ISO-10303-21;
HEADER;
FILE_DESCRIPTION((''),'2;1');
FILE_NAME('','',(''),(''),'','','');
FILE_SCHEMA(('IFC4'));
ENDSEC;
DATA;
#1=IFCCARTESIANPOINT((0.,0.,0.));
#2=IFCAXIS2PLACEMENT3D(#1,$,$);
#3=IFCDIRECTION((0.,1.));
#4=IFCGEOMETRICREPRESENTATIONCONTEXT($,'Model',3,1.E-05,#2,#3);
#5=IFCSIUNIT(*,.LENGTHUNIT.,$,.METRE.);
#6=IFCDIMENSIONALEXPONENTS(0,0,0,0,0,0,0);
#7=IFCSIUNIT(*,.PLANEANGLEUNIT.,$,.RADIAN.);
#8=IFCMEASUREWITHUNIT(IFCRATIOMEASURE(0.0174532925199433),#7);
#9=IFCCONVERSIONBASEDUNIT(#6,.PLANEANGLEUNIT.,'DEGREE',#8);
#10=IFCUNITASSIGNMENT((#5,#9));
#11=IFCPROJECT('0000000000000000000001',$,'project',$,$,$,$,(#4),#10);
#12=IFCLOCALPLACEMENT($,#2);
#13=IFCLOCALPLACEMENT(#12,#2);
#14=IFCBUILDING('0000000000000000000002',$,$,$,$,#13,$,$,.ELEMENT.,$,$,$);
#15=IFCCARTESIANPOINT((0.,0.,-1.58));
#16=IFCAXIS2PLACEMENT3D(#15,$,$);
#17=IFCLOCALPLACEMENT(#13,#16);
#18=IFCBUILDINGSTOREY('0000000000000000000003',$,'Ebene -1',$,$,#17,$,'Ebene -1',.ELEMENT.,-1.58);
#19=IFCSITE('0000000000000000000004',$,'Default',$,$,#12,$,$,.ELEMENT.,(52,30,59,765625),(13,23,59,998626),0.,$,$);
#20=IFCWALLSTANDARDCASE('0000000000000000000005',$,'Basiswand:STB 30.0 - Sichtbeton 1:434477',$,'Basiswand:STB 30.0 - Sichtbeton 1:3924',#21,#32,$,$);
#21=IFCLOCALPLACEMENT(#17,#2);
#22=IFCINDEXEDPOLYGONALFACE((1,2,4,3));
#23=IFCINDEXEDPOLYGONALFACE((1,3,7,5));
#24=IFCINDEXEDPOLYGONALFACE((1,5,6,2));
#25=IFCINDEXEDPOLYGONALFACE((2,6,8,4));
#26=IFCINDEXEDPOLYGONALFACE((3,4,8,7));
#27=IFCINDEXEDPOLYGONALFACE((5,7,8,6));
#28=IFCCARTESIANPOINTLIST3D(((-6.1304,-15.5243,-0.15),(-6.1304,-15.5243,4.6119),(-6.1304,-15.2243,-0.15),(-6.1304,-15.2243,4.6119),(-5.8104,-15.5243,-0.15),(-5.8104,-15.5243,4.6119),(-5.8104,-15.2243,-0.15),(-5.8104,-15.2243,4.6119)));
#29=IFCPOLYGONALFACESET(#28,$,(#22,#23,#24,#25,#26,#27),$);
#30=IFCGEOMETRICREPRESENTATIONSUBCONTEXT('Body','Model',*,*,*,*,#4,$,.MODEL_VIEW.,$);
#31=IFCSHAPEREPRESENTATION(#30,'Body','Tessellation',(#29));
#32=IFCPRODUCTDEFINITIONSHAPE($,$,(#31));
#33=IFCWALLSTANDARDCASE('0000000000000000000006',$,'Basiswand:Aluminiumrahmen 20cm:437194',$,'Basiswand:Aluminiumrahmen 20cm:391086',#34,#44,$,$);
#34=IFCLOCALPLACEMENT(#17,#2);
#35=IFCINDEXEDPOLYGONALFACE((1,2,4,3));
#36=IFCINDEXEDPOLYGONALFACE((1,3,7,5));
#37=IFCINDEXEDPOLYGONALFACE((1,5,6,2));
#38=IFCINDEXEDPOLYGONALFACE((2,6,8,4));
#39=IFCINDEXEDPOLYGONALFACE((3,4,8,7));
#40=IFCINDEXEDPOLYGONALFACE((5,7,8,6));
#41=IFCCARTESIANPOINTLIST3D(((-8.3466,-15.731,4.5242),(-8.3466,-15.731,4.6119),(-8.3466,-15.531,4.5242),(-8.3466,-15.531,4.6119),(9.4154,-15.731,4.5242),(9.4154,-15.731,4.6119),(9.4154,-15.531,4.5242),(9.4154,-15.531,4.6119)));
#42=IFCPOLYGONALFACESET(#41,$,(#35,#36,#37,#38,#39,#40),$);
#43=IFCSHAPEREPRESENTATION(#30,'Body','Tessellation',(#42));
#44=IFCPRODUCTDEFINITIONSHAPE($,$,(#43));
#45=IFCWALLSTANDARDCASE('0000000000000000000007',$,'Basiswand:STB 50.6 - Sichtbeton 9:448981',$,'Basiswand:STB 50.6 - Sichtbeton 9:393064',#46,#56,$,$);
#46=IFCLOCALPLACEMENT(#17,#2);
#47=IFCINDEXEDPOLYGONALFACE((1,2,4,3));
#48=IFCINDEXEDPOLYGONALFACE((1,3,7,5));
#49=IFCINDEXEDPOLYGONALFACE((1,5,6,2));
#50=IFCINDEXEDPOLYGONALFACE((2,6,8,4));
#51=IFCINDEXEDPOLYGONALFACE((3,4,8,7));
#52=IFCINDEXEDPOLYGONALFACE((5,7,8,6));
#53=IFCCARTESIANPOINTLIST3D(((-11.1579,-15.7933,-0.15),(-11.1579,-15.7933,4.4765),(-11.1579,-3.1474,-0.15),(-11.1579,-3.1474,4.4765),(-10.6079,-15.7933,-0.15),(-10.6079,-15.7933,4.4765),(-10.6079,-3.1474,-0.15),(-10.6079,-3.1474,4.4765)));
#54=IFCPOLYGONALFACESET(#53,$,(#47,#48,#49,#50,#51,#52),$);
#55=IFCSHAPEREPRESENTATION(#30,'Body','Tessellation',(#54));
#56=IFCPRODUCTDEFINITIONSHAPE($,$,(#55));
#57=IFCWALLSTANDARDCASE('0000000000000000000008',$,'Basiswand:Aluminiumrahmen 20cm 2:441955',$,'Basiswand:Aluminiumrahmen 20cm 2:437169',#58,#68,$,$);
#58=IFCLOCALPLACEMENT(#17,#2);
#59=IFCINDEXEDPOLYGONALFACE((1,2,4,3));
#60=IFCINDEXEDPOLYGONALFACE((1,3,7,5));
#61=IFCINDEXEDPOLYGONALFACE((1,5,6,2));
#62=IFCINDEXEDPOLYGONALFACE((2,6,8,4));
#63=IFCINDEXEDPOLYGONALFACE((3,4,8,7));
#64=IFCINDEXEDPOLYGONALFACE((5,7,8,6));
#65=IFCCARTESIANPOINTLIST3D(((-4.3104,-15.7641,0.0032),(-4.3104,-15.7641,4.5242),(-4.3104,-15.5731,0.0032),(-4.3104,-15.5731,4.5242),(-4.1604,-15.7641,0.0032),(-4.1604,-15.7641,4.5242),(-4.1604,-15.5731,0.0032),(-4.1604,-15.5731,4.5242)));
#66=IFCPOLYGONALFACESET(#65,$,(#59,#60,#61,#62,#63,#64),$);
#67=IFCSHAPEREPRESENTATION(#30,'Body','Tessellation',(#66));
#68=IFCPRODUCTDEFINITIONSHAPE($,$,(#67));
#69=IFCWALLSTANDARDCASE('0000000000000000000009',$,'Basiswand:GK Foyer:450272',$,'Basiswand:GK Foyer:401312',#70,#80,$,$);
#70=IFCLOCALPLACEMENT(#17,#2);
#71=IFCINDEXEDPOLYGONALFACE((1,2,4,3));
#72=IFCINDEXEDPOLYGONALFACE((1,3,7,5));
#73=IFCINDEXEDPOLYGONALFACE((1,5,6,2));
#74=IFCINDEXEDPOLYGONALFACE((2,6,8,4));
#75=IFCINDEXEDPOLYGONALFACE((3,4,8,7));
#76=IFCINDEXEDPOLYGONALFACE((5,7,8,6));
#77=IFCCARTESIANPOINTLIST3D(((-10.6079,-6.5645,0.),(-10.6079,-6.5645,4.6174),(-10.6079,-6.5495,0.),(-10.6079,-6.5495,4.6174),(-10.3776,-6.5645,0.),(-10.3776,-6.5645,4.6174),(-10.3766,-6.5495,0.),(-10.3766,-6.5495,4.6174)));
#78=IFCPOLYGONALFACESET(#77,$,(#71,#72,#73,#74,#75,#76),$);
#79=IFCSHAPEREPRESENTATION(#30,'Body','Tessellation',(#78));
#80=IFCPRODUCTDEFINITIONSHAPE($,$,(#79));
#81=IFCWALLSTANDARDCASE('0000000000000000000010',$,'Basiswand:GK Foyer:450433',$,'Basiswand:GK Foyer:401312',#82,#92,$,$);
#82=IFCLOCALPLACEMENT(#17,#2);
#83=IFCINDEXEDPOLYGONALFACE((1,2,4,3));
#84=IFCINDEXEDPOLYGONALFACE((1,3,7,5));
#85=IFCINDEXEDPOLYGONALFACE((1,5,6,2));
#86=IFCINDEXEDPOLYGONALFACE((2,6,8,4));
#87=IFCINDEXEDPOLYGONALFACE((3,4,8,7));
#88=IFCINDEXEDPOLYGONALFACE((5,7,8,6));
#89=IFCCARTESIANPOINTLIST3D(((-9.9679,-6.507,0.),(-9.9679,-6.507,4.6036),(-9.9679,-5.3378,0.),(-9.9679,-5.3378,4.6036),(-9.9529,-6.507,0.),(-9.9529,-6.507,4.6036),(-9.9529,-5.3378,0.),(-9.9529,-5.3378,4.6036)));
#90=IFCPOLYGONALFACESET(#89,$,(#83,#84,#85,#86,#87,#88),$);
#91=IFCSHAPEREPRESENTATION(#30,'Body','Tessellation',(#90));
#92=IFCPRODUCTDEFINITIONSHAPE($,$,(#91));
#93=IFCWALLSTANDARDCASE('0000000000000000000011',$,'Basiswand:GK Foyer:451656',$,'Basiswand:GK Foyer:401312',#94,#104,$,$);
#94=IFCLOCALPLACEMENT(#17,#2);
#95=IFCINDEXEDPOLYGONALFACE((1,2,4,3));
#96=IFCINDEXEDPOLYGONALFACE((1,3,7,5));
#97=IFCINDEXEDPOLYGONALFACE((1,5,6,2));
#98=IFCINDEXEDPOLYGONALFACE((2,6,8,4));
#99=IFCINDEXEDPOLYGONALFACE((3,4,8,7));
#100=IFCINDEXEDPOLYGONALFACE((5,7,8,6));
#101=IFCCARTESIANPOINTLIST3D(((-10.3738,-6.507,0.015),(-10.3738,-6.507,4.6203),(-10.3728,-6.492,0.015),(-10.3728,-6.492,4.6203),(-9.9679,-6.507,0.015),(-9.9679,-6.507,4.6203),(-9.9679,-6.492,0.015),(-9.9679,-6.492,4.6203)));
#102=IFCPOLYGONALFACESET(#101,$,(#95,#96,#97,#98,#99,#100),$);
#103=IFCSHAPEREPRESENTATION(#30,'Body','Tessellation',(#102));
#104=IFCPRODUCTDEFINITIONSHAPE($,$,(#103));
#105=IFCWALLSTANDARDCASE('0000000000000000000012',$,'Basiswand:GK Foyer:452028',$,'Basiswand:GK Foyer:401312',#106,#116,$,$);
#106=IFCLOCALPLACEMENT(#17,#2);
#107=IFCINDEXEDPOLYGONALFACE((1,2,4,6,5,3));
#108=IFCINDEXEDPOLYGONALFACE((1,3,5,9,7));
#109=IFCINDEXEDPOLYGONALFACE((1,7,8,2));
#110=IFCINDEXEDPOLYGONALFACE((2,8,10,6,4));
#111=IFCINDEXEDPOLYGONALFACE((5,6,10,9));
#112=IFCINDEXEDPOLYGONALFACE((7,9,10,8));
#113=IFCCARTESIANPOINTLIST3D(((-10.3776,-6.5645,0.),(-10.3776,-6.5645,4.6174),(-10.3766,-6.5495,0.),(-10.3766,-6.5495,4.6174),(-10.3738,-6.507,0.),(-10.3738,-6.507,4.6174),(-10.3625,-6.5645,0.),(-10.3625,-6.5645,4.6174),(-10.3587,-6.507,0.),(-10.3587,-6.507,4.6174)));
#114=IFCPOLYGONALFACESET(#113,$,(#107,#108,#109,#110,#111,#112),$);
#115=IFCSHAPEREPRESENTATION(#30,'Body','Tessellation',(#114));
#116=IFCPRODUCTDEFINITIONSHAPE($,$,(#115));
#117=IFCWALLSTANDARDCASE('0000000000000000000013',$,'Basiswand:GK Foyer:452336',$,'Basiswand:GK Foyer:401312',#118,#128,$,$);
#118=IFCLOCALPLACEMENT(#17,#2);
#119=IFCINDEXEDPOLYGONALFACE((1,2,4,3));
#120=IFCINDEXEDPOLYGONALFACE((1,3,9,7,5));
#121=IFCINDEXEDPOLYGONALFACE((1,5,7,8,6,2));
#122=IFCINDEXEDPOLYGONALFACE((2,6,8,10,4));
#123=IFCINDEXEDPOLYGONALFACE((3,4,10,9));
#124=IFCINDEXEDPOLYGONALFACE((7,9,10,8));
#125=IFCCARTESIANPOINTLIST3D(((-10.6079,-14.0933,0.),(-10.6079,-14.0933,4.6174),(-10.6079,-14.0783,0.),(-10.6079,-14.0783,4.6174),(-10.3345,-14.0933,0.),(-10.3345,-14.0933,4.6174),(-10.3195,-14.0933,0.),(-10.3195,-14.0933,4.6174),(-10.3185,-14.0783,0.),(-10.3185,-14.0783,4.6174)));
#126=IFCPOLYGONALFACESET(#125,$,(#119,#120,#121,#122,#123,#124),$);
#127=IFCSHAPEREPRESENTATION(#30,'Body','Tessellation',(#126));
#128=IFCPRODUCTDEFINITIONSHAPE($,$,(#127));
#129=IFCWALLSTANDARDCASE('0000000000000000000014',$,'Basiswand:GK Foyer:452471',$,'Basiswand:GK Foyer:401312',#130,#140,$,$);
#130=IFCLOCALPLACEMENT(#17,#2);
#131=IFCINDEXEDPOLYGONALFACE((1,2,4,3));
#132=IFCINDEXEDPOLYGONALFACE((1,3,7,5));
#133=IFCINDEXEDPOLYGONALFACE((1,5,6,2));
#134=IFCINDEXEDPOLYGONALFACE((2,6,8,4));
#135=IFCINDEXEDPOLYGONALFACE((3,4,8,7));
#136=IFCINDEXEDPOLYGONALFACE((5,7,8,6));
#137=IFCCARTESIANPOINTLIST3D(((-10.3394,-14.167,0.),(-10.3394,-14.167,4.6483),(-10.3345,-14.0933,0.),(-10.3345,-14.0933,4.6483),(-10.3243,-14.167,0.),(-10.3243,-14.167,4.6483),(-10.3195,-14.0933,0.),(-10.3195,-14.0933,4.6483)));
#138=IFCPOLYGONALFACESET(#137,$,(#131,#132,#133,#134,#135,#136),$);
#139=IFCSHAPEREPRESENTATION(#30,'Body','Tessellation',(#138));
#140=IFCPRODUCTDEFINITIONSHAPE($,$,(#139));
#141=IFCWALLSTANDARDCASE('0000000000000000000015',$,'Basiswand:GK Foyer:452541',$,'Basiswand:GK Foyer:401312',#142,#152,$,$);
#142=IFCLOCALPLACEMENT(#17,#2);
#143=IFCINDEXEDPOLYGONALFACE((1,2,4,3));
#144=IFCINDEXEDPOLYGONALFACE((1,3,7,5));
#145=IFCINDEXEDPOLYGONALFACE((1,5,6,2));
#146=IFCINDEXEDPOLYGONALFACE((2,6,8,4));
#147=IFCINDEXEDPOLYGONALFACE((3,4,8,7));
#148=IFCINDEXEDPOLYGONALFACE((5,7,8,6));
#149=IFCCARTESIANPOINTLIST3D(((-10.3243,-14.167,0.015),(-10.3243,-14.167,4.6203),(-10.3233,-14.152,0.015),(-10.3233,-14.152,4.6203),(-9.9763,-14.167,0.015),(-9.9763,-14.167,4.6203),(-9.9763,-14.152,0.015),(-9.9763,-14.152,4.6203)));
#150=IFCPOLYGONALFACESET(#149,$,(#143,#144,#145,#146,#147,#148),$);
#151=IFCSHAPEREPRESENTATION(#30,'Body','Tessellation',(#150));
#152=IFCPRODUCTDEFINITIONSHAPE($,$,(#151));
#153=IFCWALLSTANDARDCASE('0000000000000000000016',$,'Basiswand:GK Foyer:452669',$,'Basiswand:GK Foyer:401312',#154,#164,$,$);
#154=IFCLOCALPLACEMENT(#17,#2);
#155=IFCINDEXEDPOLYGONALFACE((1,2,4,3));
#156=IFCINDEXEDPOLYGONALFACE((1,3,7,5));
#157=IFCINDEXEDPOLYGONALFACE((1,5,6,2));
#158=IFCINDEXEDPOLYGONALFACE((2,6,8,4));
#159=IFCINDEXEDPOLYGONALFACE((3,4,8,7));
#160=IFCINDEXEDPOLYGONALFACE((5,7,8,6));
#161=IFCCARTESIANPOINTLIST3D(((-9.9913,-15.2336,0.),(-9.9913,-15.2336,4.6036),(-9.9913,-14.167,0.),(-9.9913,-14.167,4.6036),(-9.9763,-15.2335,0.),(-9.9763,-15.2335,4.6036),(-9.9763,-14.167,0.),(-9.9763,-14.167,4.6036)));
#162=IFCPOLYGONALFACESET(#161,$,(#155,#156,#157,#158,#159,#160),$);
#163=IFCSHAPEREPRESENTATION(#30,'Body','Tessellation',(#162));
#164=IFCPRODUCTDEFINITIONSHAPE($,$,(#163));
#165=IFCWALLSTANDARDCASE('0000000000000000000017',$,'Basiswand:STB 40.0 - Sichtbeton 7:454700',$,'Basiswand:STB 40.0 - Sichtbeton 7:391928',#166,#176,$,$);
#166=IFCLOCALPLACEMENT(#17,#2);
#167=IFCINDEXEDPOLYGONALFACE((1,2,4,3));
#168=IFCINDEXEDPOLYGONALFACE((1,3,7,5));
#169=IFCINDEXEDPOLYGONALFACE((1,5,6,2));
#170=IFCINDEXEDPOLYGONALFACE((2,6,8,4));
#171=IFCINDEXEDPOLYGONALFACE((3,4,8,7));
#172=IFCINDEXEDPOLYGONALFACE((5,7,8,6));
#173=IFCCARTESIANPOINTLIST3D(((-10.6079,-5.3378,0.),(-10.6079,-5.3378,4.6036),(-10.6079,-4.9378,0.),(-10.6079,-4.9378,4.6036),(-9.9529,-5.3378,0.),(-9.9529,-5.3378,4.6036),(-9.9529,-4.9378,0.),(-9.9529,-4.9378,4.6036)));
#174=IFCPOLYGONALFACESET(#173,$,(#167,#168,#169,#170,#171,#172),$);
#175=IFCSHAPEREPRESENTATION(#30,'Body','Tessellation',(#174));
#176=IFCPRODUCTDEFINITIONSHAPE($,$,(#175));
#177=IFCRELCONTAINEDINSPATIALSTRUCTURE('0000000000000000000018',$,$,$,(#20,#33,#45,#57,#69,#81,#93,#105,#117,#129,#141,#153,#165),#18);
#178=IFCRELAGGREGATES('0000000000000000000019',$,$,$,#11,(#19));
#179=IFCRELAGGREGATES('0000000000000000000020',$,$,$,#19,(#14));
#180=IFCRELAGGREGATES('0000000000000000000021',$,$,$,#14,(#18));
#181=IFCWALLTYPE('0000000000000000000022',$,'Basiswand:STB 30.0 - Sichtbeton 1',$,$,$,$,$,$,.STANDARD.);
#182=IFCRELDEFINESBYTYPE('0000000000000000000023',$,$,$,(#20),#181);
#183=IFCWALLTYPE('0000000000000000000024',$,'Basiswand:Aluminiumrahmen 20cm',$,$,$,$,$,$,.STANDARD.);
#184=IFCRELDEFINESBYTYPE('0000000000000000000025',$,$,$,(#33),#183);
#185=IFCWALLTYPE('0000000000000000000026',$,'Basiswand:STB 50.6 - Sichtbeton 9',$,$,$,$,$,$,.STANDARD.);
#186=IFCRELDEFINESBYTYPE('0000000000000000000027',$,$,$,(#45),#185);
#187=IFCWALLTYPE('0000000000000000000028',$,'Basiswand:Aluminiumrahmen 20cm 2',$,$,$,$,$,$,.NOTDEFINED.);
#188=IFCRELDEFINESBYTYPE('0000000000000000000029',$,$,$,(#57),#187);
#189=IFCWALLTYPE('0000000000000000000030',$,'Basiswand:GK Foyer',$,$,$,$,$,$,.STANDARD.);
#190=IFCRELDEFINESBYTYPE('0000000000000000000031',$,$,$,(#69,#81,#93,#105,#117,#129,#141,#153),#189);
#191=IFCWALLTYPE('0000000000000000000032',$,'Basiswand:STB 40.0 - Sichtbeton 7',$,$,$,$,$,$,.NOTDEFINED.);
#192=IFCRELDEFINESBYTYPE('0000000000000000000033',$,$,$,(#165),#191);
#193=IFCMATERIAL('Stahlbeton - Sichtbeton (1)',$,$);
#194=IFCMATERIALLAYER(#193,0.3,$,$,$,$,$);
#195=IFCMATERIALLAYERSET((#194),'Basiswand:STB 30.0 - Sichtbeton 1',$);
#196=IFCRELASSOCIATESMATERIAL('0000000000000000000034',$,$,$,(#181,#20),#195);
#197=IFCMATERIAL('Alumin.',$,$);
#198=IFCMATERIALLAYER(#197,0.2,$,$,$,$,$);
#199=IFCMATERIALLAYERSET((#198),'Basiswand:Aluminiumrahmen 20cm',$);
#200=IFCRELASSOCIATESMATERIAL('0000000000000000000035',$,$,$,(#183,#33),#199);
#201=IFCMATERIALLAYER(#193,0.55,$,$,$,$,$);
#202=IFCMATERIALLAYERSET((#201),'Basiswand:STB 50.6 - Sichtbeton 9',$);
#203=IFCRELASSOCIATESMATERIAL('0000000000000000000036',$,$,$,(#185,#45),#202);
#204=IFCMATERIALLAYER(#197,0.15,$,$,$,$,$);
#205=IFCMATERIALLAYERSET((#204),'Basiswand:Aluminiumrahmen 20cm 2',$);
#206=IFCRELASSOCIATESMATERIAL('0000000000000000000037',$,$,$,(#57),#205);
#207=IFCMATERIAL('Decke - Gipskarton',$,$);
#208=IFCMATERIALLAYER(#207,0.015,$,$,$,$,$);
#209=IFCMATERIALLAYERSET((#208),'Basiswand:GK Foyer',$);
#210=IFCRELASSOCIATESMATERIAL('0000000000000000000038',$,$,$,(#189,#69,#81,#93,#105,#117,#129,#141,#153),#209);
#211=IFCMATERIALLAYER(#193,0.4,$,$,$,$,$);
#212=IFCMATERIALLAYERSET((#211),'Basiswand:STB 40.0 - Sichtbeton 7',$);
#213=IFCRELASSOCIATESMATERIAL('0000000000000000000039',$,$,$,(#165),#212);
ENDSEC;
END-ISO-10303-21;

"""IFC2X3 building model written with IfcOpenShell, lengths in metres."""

from ifc_helpers import new_model, entity, si_unit, converted_unit, direction, frame, frame_2d, origin, place, context, subcontext, project, spatial, polyline, rectangle, outline, extrude, material, layer, layer_set, layer_usage, type_object, element, save


model = new_model("IFC2X3")

# Units and contexts
model_context = context("Model", 3, precision=1e-05, world=origin(), true_north=direction((0.0, 1.0)))
body_context = subcontext(model_context, "Body", "Model", "MODEL_VIEW")
ifc_project = project(units=[si_unit("LENGTHUNIT", "METRE"), converted_unit("PLANEANGLEUNIT", "DEGREE", entity("IfcRatioMeasure", 0.0174532925199433), si_unit("PLANEANGLEUNIT", "RADIAN"), dimensions=[0, 0, 0, 0, 0, 0, 0])], contexts=[model_context])

# Site, building, storey
site_placement = place(None, origin())
site = spatial("IfcSite", under=ifc_project, at=site_placement, Name="Default", CompositionType="ELEMENT", RefLatitude=(52, 30, 59, 765625), RefLongitude=(13, 23, 59, 998626), RefElevation=0.0)
building_placement = place(site_placement, origin())
building = spatial("IfcBuilding", under=site, at=building_placement, CompositionType="ELEMENT")
storey_placement = place(building_placement, frame((0.0, 0.0, -1.58)))
storey = spatial("IfcBuildingStorey", under=building, at=storey_placement, Name="Ebene -1", LongName="Ebene -1", CompositionType="ELEMENT", Elevation=-1.58)

# Walls
ifc_material_1 = material(Name="Stahlbeton - Sichtbeton (1)")
ifc_layer_1 = layer(ifc_material_1, 0.3)
ifc_layer_set_1 = layer_set([ifc_layer_1], Name="Basiswand:STB 30.0 - Sichtbeton 1")
ifc_layer_usage_1 = layer_usage(ifc_layer_set_1, "AXIS2", "NEGATIVE", 0.15)
wall_type_1 = type_object("IfcWallType", Name="Basiswand:STB 30.0 - Sichtbeton 1", PredefinedType="STANDARD", material=ifc_layer_set_1)
wall_1_placement = place(storey_placement, frame((-6.1304, -15.3743, -0.15)))
element("IfcWallStandardCase", 1, at=wall_1_placement, inside=storey, type_object=wall_type_1, material=ifc_layer_usage_1, Name="Basiswand:STB 30.0 - Sichtbeton 1:434477", ObjectType="Basiswand:STB 30.0 - Sichtbeton 1:3924", context=body_context, shape_type="SweptSolid", body=[
    extrude(rectangle(XDim=0.32, YDim=0.3, at=frame_2d((0.16, 0.0), x_axis=(-1.0, 0.0))), origin(), (0.0, 0.0, 1.0), 4.7619),
])
ifc_material_2 = material(Name="Alumin.")
ifc_layer_2 = layer(ifc_material_2, 0.2)
ifc_layer_set_2 = layer_set([ifc_layer_2], Name="Basiswand:Aluminiumrahmen 20cm")
ifc_layer_usage_2 = layer_usage(ifc_layer_set_2, "AXIS2", "POSITIVE", -0.1)
wall_type_2 = type_object("IfcWallType", Name="Basiswand:Aluminiumrahmen 20cm", PredefinedType="STANDARD", material=ifc_layer_set_2)
wall_2_placement = place(storey_placement, frame((-8.3466, -15.631, 4.5242)))
element("IfcWallStandardCase", 2, at=wall_2_placement, inside=storey, type_object=wall_type_2, material=ifc_layer_usage_2, Name="Basiswand:Aluminiumrahmen 20cm:437194", ObjectType="Basiswand:Aluminiumrahmen 20cm:391086", context=body_context, shape_type="SweptSolid", body=[
    extrude(rectangle(XDim=17.762, YDim=0.2, at=frame_2d((8.881, 0.0), x_axis=(-1.0, 0.0))), origin(), (0.0, 0.0, 1.0), 0.0878),
])
ifc_layer_3 = layer(ifc_material_1, 0.55)
ifc_layer_set_3 = layer_set([ifc_layer_3], Name="Basiswand:STB 50.6 - Sichtbeton 9")
ifc_layer_usage_3 = layer_usage(ifc_layer_set_3, "AXIS2", "NEGATIVE", 0.275)
wall_type_3 = type_object("IfcWallType", Name="Basiswand:STB 50.6 - Sichtbeton 9", PredefinedType="STANDARD", material=ifc_layer_set_3)
wall_3_placement = place(storey_placement, frame((-10.8829, -15.7933, -0.15), z_axis=(0.0, 0.0, 1.0), x_axis=(0.0, 1.0, 0.0)))
element("IfcWallStandardCase", 3, at=wall_3_placement, inside=storey, type_object=wall_type_3, material=ifc_layer_usage_3, Name="Basiswand:STB 50.6 - Sichtbeton 9:448981", ObjectType="Basiswand:STB 50.6 - Sichtbeton 9:393064", context=body_context, shape_type="SweptSolid", body=[
    extrude(rectangle(XDim=12.6459, YDim=0.55, at=frame_2d((6.323, 0.0), x_axis=(-1.0, 0.0))), origin(), (0.0, 0.0, 1.0), 4.6265),
])
ifc_layer_4 = layer(ifc_material_2, 0.15)
ifc_layer_set_4 = layer_set([ifc_layer_4], Name="Basiswand:Aluminiumrahmen 20cm 2")
ifc_layer_usage_4 = layer_usage(ifc_layer_set_4, "AXIS2", "POSITIVE", -0.075)
wall_type_4 = type_object("IfcWallType", Name="Basiswand:Aluminiumrahmen 20cm 2", PredefinedType="NOTDEFINED")
wall_4_placement = place(storey_placement, frame((-4.2354, -15.5731, 0.0032), z_axis=(0.0, 0.0, 1.0), x_axis=(0.0, -1.0, 0.0)))
element("IfcWallStandardCase", 4, at=wall_4_placement, inside=storey, type_object=wall_type_4, material=ifc_layer_usage_4, Name="Basiswand:Aluminiumrahmen 20cm 2:441955", ObjectType="Basiswand:Aluminiumrahmen 20cm 2:437169", context=body_context, shape_type="SweptSolid", body=[
    extrude(rectangle(XDim=0.191, YDim=0.15, at=frame_2d((0.0955, 0.0), x_axis=(-1.0, 0.0))), origin(), (0.0, 0.0, 1.0), 4.521),
])
ifc_material_3 = material(Name="Decke - Gipskarton")
ifc_layer_5 = layer(ifc_material_3, 0.015)
ifc_layer_set_5 = layer_set([ifc_layer_5], Name="Basiswand:GK Foyer")
ifc_layer_usage_5 = layer_usage(ifc_layer_set_5, "AXIS2", "POSITIVE", -0.0075)
wall_type_5 = type_object("IfcWallType", Name="Basiswand:GK Foyer", PredefinedType="STANDARD", material=ifc_layer_set_5)
wall_5_placement = place(storey_placement, frame((-10.6079, -6.557, 0.0)))
element("IfcWallStandardCase", 5, at=wall_5_placement, inside=storey, type_object=wall_type_5, material=ifc_layer_usage_5, Name="Basiswand:GK Foyer:450272", ObjectType="Basiswand:GK Foyer:401312", context=body_context, shape_type="SweptSolid", body=[
    extrude(outline(polyline([(0.2303, -0.0075), (0.2313, 0.0075), (0.0, 0.0075), (0.0, -0.0075), (0.2303, -0.0075)])), origin(), (0.0, 0.0, 1.0), 4.6174),
])
ifc_layer_usage_6 = layer_usage(ifc_layer_set_5, "AXIS2", "NEGATIVE", 0.0075)
wall_6_placement = place(storey_placement, frame((-9.9604, -6.507, 0.0), z_axis=(0.0, 0.0, 1.0), x_axis=(0.0, 1.0, 0.0)))
element("IfcWallStandardCase", 6, at=wall_6_placement, inside=storey, type_object=wall_type_5, material=ifc_layer_usage_6, Name="Basiswand:GK Foyer:450433", ObjectType="Basiswand:GK Foyer:401312", context=body_context, shape_type="SweptSolid", body=[
    extrude(rectangle(XDim=1.1692, YDim=0.015, at=frame_2d((0.5846, 0.0), x_axis=(-1.0, 0.0))), origin(), (0.0, 0.0, 1.0), 4.6036),
])
ifc_layer_usage_7 = layer_usage(ifc_layer_set_5, "AXIS2", "NEGATIVE", 0.0075)
wall_7_placement = place(storey_placement, frame((-10.3738, -6.4995, 0.015)))
element("IfcWallStandardCase", 7, at=wall_7_placement, inside=storey, type_object=wall_type_5, material=ifc_layer_usage_7, Name="Basiswand:GK Foyer:451656", ObjectType="Basiswand:GK Foyer:401312", context=body_context, shape_type="SweptSolid", body=[
    extrude(outline(polyline([(0.4059, -0.0075), (0.4059, 0.0075), (0.001, 0.0075), (0.0, -0.0075), (0.4059, -0.0075)])), origin(), (0.0, 0.0, 1.0), 4.6053),
])
ifc_layer_usage_8 = layer_usage(ifc_layer_set_5, "AXIS2", "POSITIVE", -0.0075)
wall_8_placement = place(storey_placement, frame((-10.3701, -6.565, 0.0), z_axis=(0.0, 0.0, 1.0), x_axis=(0.066083, 0.997814, 0.0)))
element("IfcWallStandardCase", 8, at=wall_8_placement, inside=storey, type_object=wall_type_5, material=ifc_layer_usage_8, Name="Basiswand:GK Foyer:452028", ObjectType="Basiswand:GK Foyer:401312", context=body_context, shape_type="SweptSolid", body=[
    extrude(outline(polyline([(0.0587, -0.0075), (0.0577, 0.0075), (0.015, 0.0075), (0.0, 0.0075), (0.001, -0.0075), (0.0587, -0.0075)])), origin(), (0.0, 0.0, 1.0), 4.6174),
])
ifc_layer_usage_9 = layer_usage(ifc_layer_set_5, "AXIS2", "POSITIVE", -0.0075)
wall_9_placement = place(storey_placement, frame((-10.6079, -14.0858, 0.0)))
element("IfcWallStandardCase", 9, at=wall_9_placement, inside=storey, type_object=wall_type_5, material=ifc_layer_usage_9, Name="Basiswand:GK Foyer:452336", ObjectType="Basiswand:GK Foyer:401312", context=body_context, shape_type="SweptSolid", body=[
    extrude(outline(polyline([(0.2884, -0.0075), (0.2894, 0.0075), (0.0, 0.0075), (0.0, -0.0075), (0.2734, -0.0075), (0.2884, -0.0075)])), origin(), (0.0, 0.0, 1.0), 4.6174),
])
ifc_layer_usage_10 = layer_usage(ifc_layer_set_5, "AXIS2", "POSITIVE", -0.0075)
wall_10_placement = place(storey_placement, frame((-10.3319, -14.1675, 0.0), z_axis=(0.0, 0.0, 1.0), x_axis=(0.066083, 0.997814, 0.0)))
element("IfcWallStandardCase", 10, at=wall_10_placement, inside=storey, type_object=wall_type_5, material=ifc_layer_usage_10, Name="Basiswand:GK Foyer:452471", ObjectType="Basiswand:GK Foyer:401312", context=body_context, shape_type="SweptSolid", body=[
    extrude(outline(polyline([(0.0748, -0.0075), (0.0738, 0.0075), (0.0, 0.0075), (0.001, -0.0075), (0.0748, -0.0075)])), origin(), (0.0, 0.0, 1.0), 4.6483),
])
ifc_layer_usage_11 = layer_usage(ifc_layer_set_5, "AXIS2", "NEGATIVE", 0.0075)
wall_11_placement = place(storey_placement, frame((-10.3243, -14.1595, 0.015)))
element("IfcWallStandardCase", 11, at=wall_11_placement, inside=storey, type_object=wall_type_5, material=ifc_layer_usage_11, Name="Basiswand:GK Foyer:452541", ObjectType="Basiswand:GK Foyer:401312", context=body_context, shape_type="SweptSolid", body=[
    extrude(outline(polyline([(0.348, -0.0075), (0.348, 0.0075), (0.001, 0.0075), (0.0, -0.0075), (0.348, -0.0075)])), origin(), (0.0, 0.0, 1.0), 4.6053),
])
ifc_layer_usage_12 = layer_usage(ifc_layer_set_5, "AXIS2", "NEGATIVE", 0.0075)
wall_12_placement = place(storey_placement, frame((-9.9838, -15.2336, 0.0), z_axis=(0.0, 0.0, 1.0), x_axis=(0.0, 1.0, 0.0)))
element("IfcWallStandardCase", 12, at=wall_12_placement, inside=storey, type_object=wall_type_5, material=ifc_layer_usage_12, Name="Basiswand:GK Foyer:452669", ObjectType="Basiswand:GK Foyer:401312", context=body_context, shape_type="SweptSolid", body=[
    extrude(outline(polyline([(1.0666, -0.0075), (1.0666, 0.0075), (0.0, 0.0075), (0.0001, -0.0075), (1.0666, -0.0075)])), origin(), (0.0, 0.0, 1.0), 4.6036),
])
ifc_layer_6 = layer(ifc_material_1, 0.4)
ifc_layer_set_6 = layer_set([ifc_layer_6], Name="Basiswand:STB 40.0 - Sichtbeton 7")
ifc_layer_usage_13 = layer_usage(ifc_layer_set_6, "AXIS2", "NEGATIVE", 0.2)
wall_type_6 = type_object("IfcWallType", Name="Basiswand:STB 40.0 - Sichtbeton 7", PredefinedType="NOTDEFINED")
wall_13_placement = place(storey_placement, frame((-9.9529, -5.1378, 0.0), z_axis=(0.0, 0.0, 1.0), x_axis=(-1.0, 0.0, 0.0)))
element("IfcWallStandardCase", 13, at=wall_13_placement, inside=storey, type_object=wall_type_6, material=ifc_layer_usage_13, Name="Basiswand:STB 40.0 - Sichtbeton 7:454700", ObjectType="Basiswand:STB 40.0 - Sichtbeton 7:391928", context=body_context, shape_type="SweptSolid", body=[
    extrude(rectangle(XDim=0.655, YDim=0.4, at=frame_2d((0.3275, 0.0), x_axis=(-1.0, 0.0))), origin(), (0.0, 0.0, 1.0), 4.6036),
])

save(model, "model.ifc")
